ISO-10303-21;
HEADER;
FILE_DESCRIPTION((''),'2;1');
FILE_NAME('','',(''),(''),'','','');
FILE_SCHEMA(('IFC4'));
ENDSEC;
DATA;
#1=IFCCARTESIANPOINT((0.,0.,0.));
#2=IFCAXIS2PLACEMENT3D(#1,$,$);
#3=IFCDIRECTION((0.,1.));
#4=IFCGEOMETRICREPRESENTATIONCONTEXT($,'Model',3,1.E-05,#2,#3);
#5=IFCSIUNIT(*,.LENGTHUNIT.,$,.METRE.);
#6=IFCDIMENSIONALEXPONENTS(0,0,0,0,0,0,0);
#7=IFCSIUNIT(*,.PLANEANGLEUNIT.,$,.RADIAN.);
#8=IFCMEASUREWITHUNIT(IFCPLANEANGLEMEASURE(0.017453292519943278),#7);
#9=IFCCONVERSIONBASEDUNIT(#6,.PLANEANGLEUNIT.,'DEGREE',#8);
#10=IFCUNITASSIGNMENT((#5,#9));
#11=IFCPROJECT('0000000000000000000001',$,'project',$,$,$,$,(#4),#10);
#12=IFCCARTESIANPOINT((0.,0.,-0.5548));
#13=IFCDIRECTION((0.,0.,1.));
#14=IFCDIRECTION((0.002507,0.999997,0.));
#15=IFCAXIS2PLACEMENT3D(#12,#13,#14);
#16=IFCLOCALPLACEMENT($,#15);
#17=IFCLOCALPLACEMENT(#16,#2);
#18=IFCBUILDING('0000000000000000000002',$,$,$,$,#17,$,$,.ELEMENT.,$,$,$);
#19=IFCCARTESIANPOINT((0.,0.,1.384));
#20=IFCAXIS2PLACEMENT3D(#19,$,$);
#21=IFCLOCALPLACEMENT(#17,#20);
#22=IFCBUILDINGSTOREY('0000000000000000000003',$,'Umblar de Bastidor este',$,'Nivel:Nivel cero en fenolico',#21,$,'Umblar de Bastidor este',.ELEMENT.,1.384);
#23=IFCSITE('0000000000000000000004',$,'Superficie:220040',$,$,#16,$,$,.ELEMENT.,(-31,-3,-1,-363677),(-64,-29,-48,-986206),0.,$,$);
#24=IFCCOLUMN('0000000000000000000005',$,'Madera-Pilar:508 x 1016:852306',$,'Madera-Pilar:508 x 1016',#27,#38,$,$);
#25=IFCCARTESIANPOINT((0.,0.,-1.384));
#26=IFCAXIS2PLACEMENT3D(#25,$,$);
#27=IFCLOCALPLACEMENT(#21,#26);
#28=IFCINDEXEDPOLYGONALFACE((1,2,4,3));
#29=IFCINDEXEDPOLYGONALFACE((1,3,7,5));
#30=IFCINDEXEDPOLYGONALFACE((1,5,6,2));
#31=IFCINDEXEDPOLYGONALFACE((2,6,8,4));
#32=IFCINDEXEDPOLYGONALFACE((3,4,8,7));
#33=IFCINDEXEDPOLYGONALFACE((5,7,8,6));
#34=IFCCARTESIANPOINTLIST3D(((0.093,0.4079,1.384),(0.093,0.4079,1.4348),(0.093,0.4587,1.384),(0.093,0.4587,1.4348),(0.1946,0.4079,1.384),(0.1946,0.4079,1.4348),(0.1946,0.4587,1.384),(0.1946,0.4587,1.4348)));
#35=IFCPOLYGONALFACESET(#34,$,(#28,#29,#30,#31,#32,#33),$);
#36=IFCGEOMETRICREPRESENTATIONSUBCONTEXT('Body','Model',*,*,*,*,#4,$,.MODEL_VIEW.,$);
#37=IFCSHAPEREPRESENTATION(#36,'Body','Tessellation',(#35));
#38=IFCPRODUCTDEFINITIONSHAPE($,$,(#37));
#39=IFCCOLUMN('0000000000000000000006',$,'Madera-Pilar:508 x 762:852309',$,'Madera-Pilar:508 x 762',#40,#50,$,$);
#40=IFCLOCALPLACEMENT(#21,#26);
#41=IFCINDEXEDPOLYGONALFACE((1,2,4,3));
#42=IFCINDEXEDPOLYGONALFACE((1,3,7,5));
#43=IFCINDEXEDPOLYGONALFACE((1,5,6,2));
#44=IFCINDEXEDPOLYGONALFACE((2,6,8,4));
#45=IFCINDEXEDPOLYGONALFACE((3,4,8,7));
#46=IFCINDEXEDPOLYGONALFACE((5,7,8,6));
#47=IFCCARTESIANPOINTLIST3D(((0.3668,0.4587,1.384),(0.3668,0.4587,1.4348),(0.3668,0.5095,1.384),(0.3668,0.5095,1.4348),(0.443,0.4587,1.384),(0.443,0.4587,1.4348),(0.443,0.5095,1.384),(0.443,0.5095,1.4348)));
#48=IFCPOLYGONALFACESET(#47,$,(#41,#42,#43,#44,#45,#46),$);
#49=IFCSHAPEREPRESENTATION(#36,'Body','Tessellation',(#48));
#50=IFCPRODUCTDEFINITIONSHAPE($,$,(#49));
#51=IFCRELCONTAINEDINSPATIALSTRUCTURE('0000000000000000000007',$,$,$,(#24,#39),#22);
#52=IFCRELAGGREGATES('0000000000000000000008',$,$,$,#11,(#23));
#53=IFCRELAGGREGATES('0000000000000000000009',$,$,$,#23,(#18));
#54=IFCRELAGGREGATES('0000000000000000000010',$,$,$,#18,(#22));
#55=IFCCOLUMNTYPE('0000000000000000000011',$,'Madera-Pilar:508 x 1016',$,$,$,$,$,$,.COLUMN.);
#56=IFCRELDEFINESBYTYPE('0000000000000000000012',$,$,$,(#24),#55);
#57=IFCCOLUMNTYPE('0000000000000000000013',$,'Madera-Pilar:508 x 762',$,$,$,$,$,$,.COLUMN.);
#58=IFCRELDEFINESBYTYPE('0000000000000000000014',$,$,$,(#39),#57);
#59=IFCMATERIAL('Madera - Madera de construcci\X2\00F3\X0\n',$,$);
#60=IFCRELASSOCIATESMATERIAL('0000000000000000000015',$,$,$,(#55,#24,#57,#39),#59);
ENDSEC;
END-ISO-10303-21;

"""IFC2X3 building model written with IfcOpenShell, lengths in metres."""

from ifc_helpers import new_model, entity, si_unit, converted_unit, direction, frame, frame_2d, origin, place, context, subcontext, project, spatial, rectangle, extrude, source, transform, mapped, material, type_object, type_shapes, element, save


model = new_model("IFC2X3")

# Units and contexts
model_context = context("Model", 3, precision=1e-05, world=origin(), true_north=direction((0.0, 1.0)))
body_context = subcontext(model_context, "Body", "Model", "MODEL_VIEW")
ifc_project = project(units=[si_unit("LENGTHUNIT", "METRE"), converted_unit("PLANEANGLEUNIT", "DEGREE", entity("IfcPlaneAngleMeasure", 0.017453292519943278), si_unit("PLANEANGLEUNIT", "RADIAN"), dimensions=[0, 0, 0, 0, 0, 0, 0])], contexts=[model_context])

# Site, building, storey
site_placement = place(None, frame((0.0, 0.0, -0.5548), z_axis=(0.0, 0.0, 1.0), x_axis=(0.002507, 0.999997, 0.0)))
site = spatial("IfcSite", under=ifc_project, at=site_placement, Name="Superficie:220040", CompositionType="ELEMENT", RefLatitude=(-31, -3, -1, -363677), RefLongitude=(-64, -29, -48, -986206), RefElevation=0.0)
building_placement = place(site_placement, origin())
building = spatial("IfcBuilding", under=site, at=building_placement, CompositionType="ELEMENT")
storey_placement = place(building_placement, frame((0.0, 0.0, 1.384)))
storey = spatial("IfcBuildingStorey", under=building, at=storey_placement, Name="Umblar de Bastidor este", ObjectType="Nivel:Nivel cero en fenolico", LongName="Umblar de Bastidor este", CompositionType="ELEMENT", Elevation=1.384)

# Columns
ifc_material = material(Name="Madera - Madera de construcción")
column_type_1 = type_object("IfcColumnType", Name="Madera-Pilar:508 x 1016", PredefinedType="COLUMN", material=ifc_material)
shared_shape_1 = source(origin(), body_context, "Body", "SweptSolid", [
    extrude(rectangle(XDim=0.1016, YDim=0.0508, at=frame_2d((0.0, 0.0), x_axis=(1.0, 0.0))), frame((0.1438, 0.4333, 1.384), z_axis=(0.0, 0.0, 1.0), x_axis=(-1.0, 0.0, 0.0)), (0.0, 0.0, 1.0), 0.0508),
])
type_shapes(column_type_1, [shared_shape_1])
column_1_placement = place(storey_placement, frame((0.0, 0.0, -1.384)))
element("IfcColumn", 1, at=column_1_placement, inside=storey, type_object=column_type_1, material=ifc_material, Name="Madera-Pilar:508 x 1016:852306", ObjectType="Madera-Pilar:508 x 1016", context=body_context, shape_type="MappedRepresentation", body=[
    mapped(shared_shape_1, transform((0.0, 0.0, 0.0), scale=1.0)),
])
column_type_2 = type_object("IfcColumnType", Name="Madera-Pilar:508 x 762", PredefinedType="COLUMN", material=ifc_material)
shared_shape_2 = source(origin(), body_context, "Body", "SweptSolid", [
    extrude(rectangle(XDim=0.0762, YDim=0.0508, at=frame_2d((0.0, 0.0), x_axis=(1.0, 0.0))), frame((0.4049, 0.4841, 1.384), z_axis=(0.0, 0.0, 1.0), x_axis=(-1.0, 0.0, 0.0)), (0.0, 0.0, 1.0), 0.0508),
])
type_shapes(column_type_2, [shared_shape_2])
column_2_placement = place(storey_placement, frame((0.0, 0.0, -1.384)))
element("IfcColumn", 2, at=column_2_placement, inside=storey, type_object=column_type_2, material=ifc_material, Name="Madera-Pilar:508 x 762:852309", ObjectType="Madera-Pilar:508 x 762", context=body_context, shape_type="MappedRepresentation", body=[
    mapped(shared_shape_2, transform((0.0, 0.0, 0.0), scale=1.0)),
])

save(model, "model.ifc")
